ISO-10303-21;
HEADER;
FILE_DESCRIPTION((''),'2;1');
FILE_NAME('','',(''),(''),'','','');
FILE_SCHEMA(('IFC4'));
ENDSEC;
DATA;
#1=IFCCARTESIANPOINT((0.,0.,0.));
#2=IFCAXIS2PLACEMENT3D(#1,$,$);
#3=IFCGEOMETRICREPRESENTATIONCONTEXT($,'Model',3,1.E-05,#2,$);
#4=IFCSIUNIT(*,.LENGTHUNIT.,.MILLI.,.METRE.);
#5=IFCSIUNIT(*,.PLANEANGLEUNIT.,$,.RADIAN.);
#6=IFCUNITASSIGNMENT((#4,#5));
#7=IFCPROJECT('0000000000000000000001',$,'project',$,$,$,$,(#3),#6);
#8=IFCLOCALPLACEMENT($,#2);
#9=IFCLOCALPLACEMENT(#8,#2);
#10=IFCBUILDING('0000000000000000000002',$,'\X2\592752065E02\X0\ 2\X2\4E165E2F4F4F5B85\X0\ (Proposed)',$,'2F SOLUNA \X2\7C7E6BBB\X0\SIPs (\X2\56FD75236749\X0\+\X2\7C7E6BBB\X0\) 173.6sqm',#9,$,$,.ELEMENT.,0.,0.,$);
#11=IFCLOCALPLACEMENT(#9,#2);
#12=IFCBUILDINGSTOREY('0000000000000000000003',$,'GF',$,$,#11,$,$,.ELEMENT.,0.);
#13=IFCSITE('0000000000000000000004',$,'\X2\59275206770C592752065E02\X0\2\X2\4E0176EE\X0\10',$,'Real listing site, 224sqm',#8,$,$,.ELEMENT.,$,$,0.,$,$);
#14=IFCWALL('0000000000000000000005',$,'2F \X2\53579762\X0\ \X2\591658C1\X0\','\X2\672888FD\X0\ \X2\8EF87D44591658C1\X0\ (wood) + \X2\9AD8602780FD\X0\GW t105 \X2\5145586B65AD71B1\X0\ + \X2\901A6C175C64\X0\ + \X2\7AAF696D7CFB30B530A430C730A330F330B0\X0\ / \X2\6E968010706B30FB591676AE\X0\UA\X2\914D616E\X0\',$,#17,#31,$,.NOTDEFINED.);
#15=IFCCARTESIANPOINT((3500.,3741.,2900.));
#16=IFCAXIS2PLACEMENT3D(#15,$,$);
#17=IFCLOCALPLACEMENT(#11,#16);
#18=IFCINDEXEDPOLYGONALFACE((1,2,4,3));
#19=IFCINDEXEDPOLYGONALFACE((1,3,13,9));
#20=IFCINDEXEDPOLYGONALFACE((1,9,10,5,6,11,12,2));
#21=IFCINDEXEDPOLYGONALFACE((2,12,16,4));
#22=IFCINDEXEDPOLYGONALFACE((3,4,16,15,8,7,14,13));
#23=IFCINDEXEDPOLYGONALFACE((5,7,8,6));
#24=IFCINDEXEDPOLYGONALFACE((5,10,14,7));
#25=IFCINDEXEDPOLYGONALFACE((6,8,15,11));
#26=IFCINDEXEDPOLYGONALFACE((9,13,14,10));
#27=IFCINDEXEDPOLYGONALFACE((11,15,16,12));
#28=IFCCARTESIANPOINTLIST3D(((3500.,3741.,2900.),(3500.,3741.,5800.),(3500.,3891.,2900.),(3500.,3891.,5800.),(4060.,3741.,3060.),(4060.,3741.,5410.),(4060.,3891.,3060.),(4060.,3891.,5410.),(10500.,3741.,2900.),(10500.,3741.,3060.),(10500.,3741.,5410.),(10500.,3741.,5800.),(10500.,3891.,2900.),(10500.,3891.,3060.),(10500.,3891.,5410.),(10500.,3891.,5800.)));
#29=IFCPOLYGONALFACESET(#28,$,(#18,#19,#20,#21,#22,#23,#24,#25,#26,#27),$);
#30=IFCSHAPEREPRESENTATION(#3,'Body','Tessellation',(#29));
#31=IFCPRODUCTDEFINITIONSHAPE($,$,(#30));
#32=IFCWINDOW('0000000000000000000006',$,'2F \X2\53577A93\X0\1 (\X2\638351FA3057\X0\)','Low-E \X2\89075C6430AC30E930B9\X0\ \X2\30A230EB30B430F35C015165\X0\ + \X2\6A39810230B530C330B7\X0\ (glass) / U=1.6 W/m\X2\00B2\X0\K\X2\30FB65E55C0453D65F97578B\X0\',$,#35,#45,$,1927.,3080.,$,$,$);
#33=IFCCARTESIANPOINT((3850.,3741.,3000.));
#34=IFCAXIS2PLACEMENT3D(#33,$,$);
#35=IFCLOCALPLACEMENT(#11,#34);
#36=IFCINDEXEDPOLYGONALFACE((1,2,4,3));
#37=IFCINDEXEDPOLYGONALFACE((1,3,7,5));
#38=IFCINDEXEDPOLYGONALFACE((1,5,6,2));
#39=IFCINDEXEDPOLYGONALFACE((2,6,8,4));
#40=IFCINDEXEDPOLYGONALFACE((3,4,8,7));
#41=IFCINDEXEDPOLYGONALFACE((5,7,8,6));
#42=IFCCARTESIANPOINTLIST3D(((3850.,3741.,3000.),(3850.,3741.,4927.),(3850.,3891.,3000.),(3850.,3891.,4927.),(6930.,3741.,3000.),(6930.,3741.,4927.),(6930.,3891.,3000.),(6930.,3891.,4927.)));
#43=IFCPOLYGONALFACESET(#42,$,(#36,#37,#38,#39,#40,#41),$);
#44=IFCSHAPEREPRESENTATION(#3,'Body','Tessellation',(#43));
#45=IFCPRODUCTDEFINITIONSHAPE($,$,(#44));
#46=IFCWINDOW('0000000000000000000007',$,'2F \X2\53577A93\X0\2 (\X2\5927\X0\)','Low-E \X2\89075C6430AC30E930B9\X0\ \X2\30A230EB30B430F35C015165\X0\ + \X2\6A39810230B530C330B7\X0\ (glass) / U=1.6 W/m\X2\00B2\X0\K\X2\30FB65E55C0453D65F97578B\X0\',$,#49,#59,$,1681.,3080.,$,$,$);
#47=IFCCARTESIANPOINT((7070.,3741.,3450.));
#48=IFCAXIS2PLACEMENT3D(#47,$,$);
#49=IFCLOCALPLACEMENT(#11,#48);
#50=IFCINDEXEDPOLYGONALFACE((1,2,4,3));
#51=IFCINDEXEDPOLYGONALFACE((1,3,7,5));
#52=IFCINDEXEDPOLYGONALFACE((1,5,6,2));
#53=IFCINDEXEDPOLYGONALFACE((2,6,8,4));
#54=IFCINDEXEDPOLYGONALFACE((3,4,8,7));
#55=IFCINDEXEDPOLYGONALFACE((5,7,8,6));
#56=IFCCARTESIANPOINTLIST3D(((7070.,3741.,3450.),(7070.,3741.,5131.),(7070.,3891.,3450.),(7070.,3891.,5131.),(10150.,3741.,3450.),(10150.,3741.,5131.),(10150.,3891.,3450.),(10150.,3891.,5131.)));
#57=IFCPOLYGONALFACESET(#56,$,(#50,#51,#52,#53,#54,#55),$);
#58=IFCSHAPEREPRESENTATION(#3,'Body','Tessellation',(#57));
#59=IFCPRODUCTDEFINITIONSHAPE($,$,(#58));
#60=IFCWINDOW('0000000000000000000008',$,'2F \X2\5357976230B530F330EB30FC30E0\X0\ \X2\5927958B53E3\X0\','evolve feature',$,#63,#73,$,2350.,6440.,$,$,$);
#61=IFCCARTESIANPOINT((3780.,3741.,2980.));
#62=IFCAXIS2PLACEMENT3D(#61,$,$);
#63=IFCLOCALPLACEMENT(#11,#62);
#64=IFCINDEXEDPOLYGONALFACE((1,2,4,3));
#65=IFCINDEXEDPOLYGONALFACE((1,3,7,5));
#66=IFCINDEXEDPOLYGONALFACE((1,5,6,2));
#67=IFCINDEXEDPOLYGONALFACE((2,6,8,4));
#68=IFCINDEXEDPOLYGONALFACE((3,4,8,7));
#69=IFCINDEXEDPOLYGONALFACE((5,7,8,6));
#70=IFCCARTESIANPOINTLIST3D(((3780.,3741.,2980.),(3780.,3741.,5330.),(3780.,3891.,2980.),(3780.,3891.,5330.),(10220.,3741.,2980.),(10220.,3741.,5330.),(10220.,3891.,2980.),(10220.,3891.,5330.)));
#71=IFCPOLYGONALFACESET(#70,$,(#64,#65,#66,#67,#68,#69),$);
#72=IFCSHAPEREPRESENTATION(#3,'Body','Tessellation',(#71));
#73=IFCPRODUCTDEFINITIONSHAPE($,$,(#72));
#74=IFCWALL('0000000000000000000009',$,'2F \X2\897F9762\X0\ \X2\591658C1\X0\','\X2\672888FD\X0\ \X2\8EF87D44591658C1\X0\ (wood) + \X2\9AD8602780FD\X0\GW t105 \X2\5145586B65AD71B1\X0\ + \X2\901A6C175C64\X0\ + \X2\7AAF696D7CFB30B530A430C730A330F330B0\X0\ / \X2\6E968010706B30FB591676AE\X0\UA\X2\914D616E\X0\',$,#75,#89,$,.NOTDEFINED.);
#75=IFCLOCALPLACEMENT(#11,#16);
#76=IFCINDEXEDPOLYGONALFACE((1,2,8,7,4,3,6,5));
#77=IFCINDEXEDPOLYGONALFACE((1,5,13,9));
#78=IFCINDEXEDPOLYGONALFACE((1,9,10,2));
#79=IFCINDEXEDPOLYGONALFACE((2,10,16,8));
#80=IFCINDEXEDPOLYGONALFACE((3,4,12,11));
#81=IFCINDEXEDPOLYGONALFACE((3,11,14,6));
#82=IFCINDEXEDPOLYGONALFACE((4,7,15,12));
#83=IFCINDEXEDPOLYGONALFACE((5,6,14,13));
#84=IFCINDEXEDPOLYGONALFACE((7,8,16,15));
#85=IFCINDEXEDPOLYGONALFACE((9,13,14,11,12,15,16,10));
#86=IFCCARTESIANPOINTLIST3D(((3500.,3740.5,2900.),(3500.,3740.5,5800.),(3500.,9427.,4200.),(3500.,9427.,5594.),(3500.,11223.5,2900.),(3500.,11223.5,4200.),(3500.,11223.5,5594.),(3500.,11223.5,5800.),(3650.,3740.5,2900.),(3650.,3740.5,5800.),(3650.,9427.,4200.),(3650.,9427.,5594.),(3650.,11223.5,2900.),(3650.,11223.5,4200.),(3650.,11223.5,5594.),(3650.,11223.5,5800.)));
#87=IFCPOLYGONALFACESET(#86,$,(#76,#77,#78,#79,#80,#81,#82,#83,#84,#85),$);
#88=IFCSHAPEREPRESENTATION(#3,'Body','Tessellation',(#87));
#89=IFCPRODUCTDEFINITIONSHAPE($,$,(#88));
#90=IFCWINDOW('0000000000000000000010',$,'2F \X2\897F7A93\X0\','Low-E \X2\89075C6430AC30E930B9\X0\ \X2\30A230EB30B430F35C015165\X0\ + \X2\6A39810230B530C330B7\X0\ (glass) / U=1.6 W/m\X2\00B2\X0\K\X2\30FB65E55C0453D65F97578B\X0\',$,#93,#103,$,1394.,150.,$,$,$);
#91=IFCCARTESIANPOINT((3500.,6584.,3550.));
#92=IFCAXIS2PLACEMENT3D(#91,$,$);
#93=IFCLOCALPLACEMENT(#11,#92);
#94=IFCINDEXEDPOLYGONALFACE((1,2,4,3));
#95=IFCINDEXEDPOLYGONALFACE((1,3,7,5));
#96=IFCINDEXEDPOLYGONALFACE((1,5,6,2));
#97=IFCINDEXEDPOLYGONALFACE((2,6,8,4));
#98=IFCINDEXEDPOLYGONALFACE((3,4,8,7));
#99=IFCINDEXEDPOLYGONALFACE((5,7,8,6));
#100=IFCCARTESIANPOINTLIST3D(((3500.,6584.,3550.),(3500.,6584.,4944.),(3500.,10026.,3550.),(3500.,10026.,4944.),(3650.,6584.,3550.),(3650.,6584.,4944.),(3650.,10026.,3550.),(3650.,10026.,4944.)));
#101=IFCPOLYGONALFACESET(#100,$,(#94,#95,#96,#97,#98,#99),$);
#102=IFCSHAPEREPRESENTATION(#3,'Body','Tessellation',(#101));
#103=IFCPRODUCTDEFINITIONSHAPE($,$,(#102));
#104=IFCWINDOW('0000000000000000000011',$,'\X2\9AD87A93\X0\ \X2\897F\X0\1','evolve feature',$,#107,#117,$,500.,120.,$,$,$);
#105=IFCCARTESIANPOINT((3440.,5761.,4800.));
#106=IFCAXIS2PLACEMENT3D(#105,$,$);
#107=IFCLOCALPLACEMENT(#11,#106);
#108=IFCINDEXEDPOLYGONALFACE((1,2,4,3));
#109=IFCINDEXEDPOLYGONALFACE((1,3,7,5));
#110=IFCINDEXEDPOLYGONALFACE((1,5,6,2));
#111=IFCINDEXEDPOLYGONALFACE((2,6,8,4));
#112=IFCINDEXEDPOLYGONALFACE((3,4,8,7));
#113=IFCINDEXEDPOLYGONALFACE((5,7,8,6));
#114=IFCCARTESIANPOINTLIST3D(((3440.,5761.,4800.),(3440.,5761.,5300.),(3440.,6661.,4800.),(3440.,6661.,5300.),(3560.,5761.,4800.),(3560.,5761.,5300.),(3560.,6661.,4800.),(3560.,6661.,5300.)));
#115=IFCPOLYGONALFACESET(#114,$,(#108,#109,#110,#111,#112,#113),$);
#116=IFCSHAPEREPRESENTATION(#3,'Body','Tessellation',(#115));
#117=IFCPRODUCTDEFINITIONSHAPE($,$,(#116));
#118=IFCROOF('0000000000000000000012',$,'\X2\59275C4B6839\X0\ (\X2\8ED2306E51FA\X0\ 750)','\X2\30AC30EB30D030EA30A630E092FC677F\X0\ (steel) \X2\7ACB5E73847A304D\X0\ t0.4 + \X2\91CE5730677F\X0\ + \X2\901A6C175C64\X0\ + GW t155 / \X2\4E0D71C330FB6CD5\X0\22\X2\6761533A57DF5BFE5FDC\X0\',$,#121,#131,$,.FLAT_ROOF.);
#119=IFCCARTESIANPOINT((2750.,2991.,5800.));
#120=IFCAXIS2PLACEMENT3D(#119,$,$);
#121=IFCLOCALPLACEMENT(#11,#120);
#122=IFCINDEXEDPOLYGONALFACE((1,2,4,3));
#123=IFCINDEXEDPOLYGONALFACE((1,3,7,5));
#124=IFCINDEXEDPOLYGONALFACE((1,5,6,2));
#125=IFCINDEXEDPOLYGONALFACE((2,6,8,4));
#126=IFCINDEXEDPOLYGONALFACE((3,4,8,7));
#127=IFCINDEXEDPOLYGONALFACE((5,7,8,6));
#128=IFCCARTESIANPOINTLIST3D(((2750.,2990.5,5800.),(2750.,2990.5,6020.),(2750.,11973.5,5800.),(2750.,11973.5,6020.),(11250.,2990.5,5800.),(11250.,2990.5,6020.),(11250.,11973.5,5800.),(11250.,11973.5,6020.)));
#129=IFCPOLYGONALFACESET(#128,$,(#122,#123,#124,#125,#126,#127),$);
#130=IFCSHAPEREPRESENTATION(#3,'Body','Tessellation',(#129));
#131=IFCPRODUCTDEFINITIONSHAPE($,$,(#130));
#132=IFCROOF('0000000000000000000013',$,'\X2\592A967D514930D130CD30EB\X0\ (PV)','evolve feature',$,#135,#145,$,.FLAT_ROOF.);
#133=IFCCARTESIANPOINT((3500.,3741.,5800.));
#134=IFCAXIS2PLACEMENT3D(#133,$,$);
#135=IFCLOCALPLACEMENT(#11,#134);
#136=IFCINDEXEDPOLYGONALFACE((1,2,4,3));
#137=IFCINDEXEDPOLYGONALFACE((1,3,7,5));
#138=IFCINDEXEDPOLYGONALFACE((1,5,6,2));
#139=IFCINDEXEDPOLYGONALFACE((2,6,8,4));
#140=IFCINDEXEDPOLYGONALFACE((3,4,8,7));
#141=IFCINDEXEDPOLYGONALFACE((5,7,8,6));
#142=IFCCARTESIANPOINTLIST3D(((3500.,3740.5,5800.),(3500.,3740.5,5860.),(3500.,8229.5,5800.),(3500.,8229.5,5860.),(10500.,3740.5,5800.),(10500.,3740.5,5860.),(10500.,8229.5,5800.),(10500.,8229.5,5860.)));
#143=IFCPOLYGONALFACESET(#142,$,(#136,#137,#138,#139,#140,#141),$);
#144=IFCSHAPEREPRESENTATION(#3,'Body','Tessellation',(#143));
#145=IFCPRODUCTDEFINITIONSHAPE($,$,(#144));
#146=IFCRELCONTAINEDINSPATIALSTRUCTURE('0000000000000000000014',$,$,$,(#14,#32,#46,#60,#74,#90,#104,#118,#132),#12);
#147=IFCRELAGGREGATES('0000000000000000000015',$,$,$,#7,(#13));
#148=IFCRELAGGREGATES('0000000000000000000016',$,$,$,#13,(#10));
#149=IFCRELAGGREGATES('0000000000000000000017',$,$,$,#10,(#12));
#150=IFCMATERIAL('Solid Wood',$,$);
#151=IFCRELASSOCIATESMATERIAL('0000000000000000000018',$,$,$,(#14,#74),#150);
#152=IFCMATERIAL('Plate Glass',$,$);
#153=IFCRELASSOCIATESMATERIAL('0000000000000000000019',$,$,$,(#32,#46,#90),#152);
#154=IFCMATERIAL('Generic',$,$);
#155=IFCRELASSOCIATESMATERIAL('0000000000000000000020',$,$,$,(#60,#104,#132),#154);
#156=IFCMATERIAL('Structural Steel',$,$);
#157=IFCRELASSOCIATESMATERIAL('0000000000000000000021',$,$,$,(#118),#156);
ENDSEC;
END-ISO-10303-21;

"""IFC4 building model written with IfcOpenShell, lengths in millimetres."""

from ifc_helpers import new_model, si_unit, frame, frame_2d, origin, place, context, project, spatial, rectangle, extrude, material, element, fill, save


model = new_model("IFC4")

# Units and contexts
model_context = context("Model", 3, precision=1e-05, world=origin())
ifc_project = project(units=[si_unit("LENGTHUNIT", "METRE", prefix="MILLI"), si_unit("PLANEANGLEUNIT", "RADIAN")], contexts=[model_context])

# Site, building, storey
site_placement = place(None, origin())
site = spatial("IfcSite", under=ifc_project, at=site_placement, Name="大分県大分市2丁目10", ObjectType="Real listing site, 224sqm", CompositionType="ELEMENT", RefElevation=0.0)
building_placement = place(site_placement, origin())
building = spatial("IfcBuilding", under=site, at=building_placement, Name="大分市 2世帯住宅 (Proposed)", ObjectType="2F SOLUNA 籾殻SIPs (国産杉+籾殻) 173.6sqm", CompositionType="ELEMENT", ElevationOfRefHeight=0.0, ElevationOfTerrain=0.0)
storey_placement = place(building_placement, origin())
storey = spatial("IfcBuildingStorey", under=building, at=storey_placement, Name="GF", CompositionType="ELEMENT", Elevation=0.0)

# Shared definitions
ifc_material_1 = material(Name="Solid Wood")
ifc_material_2 = material(Name="Generic")

# Shared definitions
ifc_material_3 = material(Name="Plate Glass")

# Walls, openings, windows
wall_1_placement = place(storey_placement, frame((3500.0, 3741.0, 2900.0)))
wall_1 = element("IfcWall", 1, at=wall_1_placement, inside=storey, material=ifc_material_1, Name="2F 南面 外壁", Description="木製 軸組外壁 (wood) + 高性能GW t105 充填断熱 + 通気層 + 窯業系サイディング / 準耐火・外皮UA配慮", PredefinedType="NOTDEFINED", context=model_context, shape_type="SweptSolid", body=[
    extrude(rectangle(XDim=7000.0, YDim=150.0, at=frame_2d((3500.0, 75.0))), frame((3500.0, 3741.0, 2900.0)), (0.0, 0.0, 1.0), 2900.0),
])
opening_1_placement = place(storey_placement, frame((3850.0, 3741.0, 3000.0)))
opening_1 = element("IfcOpeningElement", 2, at=opening_1_placement, cuts=wall_1, PredefinedType="NOTDEFINED", context=model_context, shape_type="SweptSolid", body=[
    extrude(rectangle(XDim=3080.0, YDim=150.0, at=frame_2d((1540.0, 75.0))), frame((3850.0, 3741.0, 3000.0)), (0.0, 0.0, 1.0), 1927.0),
])
opening_2_placement = place(storey_placement, frame((7070.0, 3741.0, 3450.0)))
opening_2 = element("IfcOpeningElement", 3, at=opening_2_placement, cuts=wall_1, PredefinedType="NOTDEFINED", context=model_context, shape_type="SweptSolid", body=[
    extrude(rectangle(XDim=3080.0, YDim=150.0, at=frame_2d((1540.0, 75.0))), frame((7070.0, 3741.0, 3450.0)), (0.0, 0.0, 1.0), 1681.0),
])
opening_3_placement = place(storey_placement, frame((3780.0, 3741.0, 2980.0)))
opening_3 = element("IfcOpeningElement", 4, at=opening_3_placement, cuts=wall_1, PredefinedType="NOTDEFINED", context=model_context, shape_type="SweptSolid", body=[
    extrude(rectangle(XDim=6440.0, YDim=150.0, at=frame_2d((3220.0, 75.0))), frame((3780.0, 3741.0, 2980.0)), (0.0, 0.0, 1.0), 2350.0),
])
window_1_placement = place(storey_placement, frame((3850.0, 3741.0, 3000.0)))
window_1 = element("IfcWindow", 5, at=window_1_placement, inside=storey, material=ifc_material_3, Name="2F 南窓1 (掃出し)", Description="Low-E 複層ガラス アルゴン封入 + 樹脂サッシ (glass) / U=1.6 W/m²K・日射取得型", OverallHeight=1927.0, OverallWidth=3080.0, context=model_context, shape_type="SweptSolid", body=[
    extrude(rectangle(XDim=3080.0, YDim=150.0, at=frame_2d((1540.0, 75.0))), frame((3850.0, 3741.0, 3000.0)), (0.0, 0.0, 1.0), 1927.0),
])
fill(opening_1, window_1)
window_2_placement = place(storey_placement, frame((7070.0, 3741.0, 3450.0)))
window_2 = element("IfcWindow", 6, at=window_2_placement, inside=storey, material=ifc_material_3, Name="2F 南窓2 (大)", Description="Low-E 複層ガラス アルゴン封入 + 樹脂サッシ (glass) / U=1.6 W/m²K・日射取得型", OverallHeight=1681.0, OverallWidth=3080.0, context=model_context, shape_type="SweptSolid", body=[
    extrude(rectangle(XDim=3080.0, YDim=150.0, at=frame_2d((1540.0, 75.0))), frame((7070.0, 3741.0, 3450.0)), (0.0, 0.0, 1.0), 1681.0),
])
fill(opening_2, window_2)
window_3_placement = place(storey_placement, frame((3780.0, 3741.0, 2980.0)))
window_3 = element("IfcWindow", 7, at=window_3_placement, inside=storey, material=ifc_material_2, Name="2F 南面サンルーム 大開口", Description="evolve feature", OverallHeight=2350.0, OverallWidth=6440.0, context=model_context, shape_type="SweptSolid", body=[
    extrude(rectangle(XDim=6440.0, YDim=150.0, at=frame_2d((3220.0, 75.0))), frame((3780.0, 3741.0, 2980.0)), (0.0, 0.0, 1.0), 2350.0),
])
fill(opening_3, window_3)
wall_2_placement = place(storey_placement, frame((3500.0, 3741.0, 2900.0)))
wall_2 = element("IfcWall", 8, at=wall_2_placement, inside=storey, material=ifc_material_1, Name="2F 西面 外壁", Description="木製 軸組外壁 (wood) + 高性能GW t105 充填断熱 + 通気層 + 窯業系サイディング / 準耐火・外皮UA配慮", PredefinedType="NOTDEFINED", context=model_context, shape_type="SweptSolid", body=[
    extrude(rectangle(XDim=150.0, YDim=7483.0, at=frame_2d((75.0, 3741.0))), frame((3500.0, 3741.0, 2900.0)), (0.0, 0.0, 1.0), 2900.0),
])
opening_4_placement = place(storey_placement, frame((3500.0, 6584.0, 3550.0)))
opening_4 = element("IfcOpeningElement", 9, at=opening_4_placement, cuts=wall_2, PredefinedType="NOTDEFINED", context=model_context, shape_type="SweptSolid", body=[
    extrude(rectangle(XDim=150.0, YDim=3442.0, at=frame_2d((75.0, 1721.0))), frame((3500.0, 6584.0, 3550.0)), (0.0, 0.0, 1.0), 1394.0),
])
opening_5_placement = place(storey_placement, frame((3440.0, 5761.0, 4800.0)))
opening_5 = element("IfcOpeningElement", 10, at=opening_5_placement, cuts=wall_2, PredefinedType="NOTDEFINED", context=model_context, shape_type="SweptSolid", body=[
    extrude(rectangle(XDim=120.0, YDim=900.0, at=frame_2d((60.0, 450.0))), frame((3440.0, 5761.0, 4800.0)), (0.0, 0.0, 1.0), 500.0),
])
window_4_placement = place(storey_placement, frame((3500.0, 6584.0, 3550.0)))
window_4 = element("IfcWindow", 11, at=window_4_placement, inside=storey, material=ifc_material_3, Name="2F 西窓", Description="Low-E 複層ガラス アルゴン封入 + 樹脂サッシ (glass) / U=1.6 W/m²K・日射取得型", OverallHeight=1394.0, OverallWidth=150.0, context=model_context, shape_type="SweptSolid", body=[
    extrude(rectangle(XDim=150.0, YDim=3442.0, at=frame_2d((75.0, 1721.0))), frame((3500.0, 6584.0, 3550.0)), (0.0, 0.0, 1.0), 1394.0),
])
fill(opening_4, window_4)
window_5_placement = place(storey_placement, frame((3440.0, 5761.0, 4800.0)))
window_5 = element("IfcWindow", 12, at=window_5_placement, inside=storey, material=ifc_material_2, Name="高窓 西1", Description="evolve feature", OverallHeight=500.0, OverallWidth=120.0, context=model_context, shape_type="SweptSolid", body=[
    extrude(rectangle(XDim=120.0, YDim=900.0, at=frame_2d((60.0, 450.0))), frame((3440.0, 5761.0, 4800.0)), (0.0, 0.0, 1.0), 500.0),
])
fill(opening_5, window_5)

# Roofs
ifc_material_4 = material(Name="Structural Steel")
roof_1_placement = place(storey_placement, frame((2750.0, 2991.0, 5800.0)))
element("IfcRoof", 13, at=roof_1_placement, inside=storey, material=ifc_material_4, Name="大屋根 (軒の出 750)", Description="ガルバリウム鋼板 (steel) 立平葺き t0.4 + 野地板 + 通気層 + GW t155 / 不燃・法22条区域対応", PredefinedType="FLAT_ROOF", context=model_context, shape_type="SweptSolid", body=[
    extrude(rectangle(XDim=8500.0, YDim=8983.0, at=frame_2d((4250.0, 4491.0))), frame((2750.0, 2991.0, 5800.0)), (0.0, 0.0, 1.0), 220.0),
])
roof_2_placement = place(storey_placement, frame((3500.0, 3741.0, 5800.0)))
element("IfcRoof", 14, at=roof_2_placement, inside=storey, material=ifc_material_2, Name="太陽光パネル (PV)", Description="evolve feature", PredefinedType="FLAT_ROOF", context=model_context, shape_type="SweptSolid", body=[
    extrude(rectangle(XDim=7000.0, YDim=4489.0, at=frame_2d((3500.0, 2244.0))), frame((3500.0, 3741.0, 5800.0)), (0.0, 0.0, 1.0), 60.0),
])

save(model, "model.ifc")
